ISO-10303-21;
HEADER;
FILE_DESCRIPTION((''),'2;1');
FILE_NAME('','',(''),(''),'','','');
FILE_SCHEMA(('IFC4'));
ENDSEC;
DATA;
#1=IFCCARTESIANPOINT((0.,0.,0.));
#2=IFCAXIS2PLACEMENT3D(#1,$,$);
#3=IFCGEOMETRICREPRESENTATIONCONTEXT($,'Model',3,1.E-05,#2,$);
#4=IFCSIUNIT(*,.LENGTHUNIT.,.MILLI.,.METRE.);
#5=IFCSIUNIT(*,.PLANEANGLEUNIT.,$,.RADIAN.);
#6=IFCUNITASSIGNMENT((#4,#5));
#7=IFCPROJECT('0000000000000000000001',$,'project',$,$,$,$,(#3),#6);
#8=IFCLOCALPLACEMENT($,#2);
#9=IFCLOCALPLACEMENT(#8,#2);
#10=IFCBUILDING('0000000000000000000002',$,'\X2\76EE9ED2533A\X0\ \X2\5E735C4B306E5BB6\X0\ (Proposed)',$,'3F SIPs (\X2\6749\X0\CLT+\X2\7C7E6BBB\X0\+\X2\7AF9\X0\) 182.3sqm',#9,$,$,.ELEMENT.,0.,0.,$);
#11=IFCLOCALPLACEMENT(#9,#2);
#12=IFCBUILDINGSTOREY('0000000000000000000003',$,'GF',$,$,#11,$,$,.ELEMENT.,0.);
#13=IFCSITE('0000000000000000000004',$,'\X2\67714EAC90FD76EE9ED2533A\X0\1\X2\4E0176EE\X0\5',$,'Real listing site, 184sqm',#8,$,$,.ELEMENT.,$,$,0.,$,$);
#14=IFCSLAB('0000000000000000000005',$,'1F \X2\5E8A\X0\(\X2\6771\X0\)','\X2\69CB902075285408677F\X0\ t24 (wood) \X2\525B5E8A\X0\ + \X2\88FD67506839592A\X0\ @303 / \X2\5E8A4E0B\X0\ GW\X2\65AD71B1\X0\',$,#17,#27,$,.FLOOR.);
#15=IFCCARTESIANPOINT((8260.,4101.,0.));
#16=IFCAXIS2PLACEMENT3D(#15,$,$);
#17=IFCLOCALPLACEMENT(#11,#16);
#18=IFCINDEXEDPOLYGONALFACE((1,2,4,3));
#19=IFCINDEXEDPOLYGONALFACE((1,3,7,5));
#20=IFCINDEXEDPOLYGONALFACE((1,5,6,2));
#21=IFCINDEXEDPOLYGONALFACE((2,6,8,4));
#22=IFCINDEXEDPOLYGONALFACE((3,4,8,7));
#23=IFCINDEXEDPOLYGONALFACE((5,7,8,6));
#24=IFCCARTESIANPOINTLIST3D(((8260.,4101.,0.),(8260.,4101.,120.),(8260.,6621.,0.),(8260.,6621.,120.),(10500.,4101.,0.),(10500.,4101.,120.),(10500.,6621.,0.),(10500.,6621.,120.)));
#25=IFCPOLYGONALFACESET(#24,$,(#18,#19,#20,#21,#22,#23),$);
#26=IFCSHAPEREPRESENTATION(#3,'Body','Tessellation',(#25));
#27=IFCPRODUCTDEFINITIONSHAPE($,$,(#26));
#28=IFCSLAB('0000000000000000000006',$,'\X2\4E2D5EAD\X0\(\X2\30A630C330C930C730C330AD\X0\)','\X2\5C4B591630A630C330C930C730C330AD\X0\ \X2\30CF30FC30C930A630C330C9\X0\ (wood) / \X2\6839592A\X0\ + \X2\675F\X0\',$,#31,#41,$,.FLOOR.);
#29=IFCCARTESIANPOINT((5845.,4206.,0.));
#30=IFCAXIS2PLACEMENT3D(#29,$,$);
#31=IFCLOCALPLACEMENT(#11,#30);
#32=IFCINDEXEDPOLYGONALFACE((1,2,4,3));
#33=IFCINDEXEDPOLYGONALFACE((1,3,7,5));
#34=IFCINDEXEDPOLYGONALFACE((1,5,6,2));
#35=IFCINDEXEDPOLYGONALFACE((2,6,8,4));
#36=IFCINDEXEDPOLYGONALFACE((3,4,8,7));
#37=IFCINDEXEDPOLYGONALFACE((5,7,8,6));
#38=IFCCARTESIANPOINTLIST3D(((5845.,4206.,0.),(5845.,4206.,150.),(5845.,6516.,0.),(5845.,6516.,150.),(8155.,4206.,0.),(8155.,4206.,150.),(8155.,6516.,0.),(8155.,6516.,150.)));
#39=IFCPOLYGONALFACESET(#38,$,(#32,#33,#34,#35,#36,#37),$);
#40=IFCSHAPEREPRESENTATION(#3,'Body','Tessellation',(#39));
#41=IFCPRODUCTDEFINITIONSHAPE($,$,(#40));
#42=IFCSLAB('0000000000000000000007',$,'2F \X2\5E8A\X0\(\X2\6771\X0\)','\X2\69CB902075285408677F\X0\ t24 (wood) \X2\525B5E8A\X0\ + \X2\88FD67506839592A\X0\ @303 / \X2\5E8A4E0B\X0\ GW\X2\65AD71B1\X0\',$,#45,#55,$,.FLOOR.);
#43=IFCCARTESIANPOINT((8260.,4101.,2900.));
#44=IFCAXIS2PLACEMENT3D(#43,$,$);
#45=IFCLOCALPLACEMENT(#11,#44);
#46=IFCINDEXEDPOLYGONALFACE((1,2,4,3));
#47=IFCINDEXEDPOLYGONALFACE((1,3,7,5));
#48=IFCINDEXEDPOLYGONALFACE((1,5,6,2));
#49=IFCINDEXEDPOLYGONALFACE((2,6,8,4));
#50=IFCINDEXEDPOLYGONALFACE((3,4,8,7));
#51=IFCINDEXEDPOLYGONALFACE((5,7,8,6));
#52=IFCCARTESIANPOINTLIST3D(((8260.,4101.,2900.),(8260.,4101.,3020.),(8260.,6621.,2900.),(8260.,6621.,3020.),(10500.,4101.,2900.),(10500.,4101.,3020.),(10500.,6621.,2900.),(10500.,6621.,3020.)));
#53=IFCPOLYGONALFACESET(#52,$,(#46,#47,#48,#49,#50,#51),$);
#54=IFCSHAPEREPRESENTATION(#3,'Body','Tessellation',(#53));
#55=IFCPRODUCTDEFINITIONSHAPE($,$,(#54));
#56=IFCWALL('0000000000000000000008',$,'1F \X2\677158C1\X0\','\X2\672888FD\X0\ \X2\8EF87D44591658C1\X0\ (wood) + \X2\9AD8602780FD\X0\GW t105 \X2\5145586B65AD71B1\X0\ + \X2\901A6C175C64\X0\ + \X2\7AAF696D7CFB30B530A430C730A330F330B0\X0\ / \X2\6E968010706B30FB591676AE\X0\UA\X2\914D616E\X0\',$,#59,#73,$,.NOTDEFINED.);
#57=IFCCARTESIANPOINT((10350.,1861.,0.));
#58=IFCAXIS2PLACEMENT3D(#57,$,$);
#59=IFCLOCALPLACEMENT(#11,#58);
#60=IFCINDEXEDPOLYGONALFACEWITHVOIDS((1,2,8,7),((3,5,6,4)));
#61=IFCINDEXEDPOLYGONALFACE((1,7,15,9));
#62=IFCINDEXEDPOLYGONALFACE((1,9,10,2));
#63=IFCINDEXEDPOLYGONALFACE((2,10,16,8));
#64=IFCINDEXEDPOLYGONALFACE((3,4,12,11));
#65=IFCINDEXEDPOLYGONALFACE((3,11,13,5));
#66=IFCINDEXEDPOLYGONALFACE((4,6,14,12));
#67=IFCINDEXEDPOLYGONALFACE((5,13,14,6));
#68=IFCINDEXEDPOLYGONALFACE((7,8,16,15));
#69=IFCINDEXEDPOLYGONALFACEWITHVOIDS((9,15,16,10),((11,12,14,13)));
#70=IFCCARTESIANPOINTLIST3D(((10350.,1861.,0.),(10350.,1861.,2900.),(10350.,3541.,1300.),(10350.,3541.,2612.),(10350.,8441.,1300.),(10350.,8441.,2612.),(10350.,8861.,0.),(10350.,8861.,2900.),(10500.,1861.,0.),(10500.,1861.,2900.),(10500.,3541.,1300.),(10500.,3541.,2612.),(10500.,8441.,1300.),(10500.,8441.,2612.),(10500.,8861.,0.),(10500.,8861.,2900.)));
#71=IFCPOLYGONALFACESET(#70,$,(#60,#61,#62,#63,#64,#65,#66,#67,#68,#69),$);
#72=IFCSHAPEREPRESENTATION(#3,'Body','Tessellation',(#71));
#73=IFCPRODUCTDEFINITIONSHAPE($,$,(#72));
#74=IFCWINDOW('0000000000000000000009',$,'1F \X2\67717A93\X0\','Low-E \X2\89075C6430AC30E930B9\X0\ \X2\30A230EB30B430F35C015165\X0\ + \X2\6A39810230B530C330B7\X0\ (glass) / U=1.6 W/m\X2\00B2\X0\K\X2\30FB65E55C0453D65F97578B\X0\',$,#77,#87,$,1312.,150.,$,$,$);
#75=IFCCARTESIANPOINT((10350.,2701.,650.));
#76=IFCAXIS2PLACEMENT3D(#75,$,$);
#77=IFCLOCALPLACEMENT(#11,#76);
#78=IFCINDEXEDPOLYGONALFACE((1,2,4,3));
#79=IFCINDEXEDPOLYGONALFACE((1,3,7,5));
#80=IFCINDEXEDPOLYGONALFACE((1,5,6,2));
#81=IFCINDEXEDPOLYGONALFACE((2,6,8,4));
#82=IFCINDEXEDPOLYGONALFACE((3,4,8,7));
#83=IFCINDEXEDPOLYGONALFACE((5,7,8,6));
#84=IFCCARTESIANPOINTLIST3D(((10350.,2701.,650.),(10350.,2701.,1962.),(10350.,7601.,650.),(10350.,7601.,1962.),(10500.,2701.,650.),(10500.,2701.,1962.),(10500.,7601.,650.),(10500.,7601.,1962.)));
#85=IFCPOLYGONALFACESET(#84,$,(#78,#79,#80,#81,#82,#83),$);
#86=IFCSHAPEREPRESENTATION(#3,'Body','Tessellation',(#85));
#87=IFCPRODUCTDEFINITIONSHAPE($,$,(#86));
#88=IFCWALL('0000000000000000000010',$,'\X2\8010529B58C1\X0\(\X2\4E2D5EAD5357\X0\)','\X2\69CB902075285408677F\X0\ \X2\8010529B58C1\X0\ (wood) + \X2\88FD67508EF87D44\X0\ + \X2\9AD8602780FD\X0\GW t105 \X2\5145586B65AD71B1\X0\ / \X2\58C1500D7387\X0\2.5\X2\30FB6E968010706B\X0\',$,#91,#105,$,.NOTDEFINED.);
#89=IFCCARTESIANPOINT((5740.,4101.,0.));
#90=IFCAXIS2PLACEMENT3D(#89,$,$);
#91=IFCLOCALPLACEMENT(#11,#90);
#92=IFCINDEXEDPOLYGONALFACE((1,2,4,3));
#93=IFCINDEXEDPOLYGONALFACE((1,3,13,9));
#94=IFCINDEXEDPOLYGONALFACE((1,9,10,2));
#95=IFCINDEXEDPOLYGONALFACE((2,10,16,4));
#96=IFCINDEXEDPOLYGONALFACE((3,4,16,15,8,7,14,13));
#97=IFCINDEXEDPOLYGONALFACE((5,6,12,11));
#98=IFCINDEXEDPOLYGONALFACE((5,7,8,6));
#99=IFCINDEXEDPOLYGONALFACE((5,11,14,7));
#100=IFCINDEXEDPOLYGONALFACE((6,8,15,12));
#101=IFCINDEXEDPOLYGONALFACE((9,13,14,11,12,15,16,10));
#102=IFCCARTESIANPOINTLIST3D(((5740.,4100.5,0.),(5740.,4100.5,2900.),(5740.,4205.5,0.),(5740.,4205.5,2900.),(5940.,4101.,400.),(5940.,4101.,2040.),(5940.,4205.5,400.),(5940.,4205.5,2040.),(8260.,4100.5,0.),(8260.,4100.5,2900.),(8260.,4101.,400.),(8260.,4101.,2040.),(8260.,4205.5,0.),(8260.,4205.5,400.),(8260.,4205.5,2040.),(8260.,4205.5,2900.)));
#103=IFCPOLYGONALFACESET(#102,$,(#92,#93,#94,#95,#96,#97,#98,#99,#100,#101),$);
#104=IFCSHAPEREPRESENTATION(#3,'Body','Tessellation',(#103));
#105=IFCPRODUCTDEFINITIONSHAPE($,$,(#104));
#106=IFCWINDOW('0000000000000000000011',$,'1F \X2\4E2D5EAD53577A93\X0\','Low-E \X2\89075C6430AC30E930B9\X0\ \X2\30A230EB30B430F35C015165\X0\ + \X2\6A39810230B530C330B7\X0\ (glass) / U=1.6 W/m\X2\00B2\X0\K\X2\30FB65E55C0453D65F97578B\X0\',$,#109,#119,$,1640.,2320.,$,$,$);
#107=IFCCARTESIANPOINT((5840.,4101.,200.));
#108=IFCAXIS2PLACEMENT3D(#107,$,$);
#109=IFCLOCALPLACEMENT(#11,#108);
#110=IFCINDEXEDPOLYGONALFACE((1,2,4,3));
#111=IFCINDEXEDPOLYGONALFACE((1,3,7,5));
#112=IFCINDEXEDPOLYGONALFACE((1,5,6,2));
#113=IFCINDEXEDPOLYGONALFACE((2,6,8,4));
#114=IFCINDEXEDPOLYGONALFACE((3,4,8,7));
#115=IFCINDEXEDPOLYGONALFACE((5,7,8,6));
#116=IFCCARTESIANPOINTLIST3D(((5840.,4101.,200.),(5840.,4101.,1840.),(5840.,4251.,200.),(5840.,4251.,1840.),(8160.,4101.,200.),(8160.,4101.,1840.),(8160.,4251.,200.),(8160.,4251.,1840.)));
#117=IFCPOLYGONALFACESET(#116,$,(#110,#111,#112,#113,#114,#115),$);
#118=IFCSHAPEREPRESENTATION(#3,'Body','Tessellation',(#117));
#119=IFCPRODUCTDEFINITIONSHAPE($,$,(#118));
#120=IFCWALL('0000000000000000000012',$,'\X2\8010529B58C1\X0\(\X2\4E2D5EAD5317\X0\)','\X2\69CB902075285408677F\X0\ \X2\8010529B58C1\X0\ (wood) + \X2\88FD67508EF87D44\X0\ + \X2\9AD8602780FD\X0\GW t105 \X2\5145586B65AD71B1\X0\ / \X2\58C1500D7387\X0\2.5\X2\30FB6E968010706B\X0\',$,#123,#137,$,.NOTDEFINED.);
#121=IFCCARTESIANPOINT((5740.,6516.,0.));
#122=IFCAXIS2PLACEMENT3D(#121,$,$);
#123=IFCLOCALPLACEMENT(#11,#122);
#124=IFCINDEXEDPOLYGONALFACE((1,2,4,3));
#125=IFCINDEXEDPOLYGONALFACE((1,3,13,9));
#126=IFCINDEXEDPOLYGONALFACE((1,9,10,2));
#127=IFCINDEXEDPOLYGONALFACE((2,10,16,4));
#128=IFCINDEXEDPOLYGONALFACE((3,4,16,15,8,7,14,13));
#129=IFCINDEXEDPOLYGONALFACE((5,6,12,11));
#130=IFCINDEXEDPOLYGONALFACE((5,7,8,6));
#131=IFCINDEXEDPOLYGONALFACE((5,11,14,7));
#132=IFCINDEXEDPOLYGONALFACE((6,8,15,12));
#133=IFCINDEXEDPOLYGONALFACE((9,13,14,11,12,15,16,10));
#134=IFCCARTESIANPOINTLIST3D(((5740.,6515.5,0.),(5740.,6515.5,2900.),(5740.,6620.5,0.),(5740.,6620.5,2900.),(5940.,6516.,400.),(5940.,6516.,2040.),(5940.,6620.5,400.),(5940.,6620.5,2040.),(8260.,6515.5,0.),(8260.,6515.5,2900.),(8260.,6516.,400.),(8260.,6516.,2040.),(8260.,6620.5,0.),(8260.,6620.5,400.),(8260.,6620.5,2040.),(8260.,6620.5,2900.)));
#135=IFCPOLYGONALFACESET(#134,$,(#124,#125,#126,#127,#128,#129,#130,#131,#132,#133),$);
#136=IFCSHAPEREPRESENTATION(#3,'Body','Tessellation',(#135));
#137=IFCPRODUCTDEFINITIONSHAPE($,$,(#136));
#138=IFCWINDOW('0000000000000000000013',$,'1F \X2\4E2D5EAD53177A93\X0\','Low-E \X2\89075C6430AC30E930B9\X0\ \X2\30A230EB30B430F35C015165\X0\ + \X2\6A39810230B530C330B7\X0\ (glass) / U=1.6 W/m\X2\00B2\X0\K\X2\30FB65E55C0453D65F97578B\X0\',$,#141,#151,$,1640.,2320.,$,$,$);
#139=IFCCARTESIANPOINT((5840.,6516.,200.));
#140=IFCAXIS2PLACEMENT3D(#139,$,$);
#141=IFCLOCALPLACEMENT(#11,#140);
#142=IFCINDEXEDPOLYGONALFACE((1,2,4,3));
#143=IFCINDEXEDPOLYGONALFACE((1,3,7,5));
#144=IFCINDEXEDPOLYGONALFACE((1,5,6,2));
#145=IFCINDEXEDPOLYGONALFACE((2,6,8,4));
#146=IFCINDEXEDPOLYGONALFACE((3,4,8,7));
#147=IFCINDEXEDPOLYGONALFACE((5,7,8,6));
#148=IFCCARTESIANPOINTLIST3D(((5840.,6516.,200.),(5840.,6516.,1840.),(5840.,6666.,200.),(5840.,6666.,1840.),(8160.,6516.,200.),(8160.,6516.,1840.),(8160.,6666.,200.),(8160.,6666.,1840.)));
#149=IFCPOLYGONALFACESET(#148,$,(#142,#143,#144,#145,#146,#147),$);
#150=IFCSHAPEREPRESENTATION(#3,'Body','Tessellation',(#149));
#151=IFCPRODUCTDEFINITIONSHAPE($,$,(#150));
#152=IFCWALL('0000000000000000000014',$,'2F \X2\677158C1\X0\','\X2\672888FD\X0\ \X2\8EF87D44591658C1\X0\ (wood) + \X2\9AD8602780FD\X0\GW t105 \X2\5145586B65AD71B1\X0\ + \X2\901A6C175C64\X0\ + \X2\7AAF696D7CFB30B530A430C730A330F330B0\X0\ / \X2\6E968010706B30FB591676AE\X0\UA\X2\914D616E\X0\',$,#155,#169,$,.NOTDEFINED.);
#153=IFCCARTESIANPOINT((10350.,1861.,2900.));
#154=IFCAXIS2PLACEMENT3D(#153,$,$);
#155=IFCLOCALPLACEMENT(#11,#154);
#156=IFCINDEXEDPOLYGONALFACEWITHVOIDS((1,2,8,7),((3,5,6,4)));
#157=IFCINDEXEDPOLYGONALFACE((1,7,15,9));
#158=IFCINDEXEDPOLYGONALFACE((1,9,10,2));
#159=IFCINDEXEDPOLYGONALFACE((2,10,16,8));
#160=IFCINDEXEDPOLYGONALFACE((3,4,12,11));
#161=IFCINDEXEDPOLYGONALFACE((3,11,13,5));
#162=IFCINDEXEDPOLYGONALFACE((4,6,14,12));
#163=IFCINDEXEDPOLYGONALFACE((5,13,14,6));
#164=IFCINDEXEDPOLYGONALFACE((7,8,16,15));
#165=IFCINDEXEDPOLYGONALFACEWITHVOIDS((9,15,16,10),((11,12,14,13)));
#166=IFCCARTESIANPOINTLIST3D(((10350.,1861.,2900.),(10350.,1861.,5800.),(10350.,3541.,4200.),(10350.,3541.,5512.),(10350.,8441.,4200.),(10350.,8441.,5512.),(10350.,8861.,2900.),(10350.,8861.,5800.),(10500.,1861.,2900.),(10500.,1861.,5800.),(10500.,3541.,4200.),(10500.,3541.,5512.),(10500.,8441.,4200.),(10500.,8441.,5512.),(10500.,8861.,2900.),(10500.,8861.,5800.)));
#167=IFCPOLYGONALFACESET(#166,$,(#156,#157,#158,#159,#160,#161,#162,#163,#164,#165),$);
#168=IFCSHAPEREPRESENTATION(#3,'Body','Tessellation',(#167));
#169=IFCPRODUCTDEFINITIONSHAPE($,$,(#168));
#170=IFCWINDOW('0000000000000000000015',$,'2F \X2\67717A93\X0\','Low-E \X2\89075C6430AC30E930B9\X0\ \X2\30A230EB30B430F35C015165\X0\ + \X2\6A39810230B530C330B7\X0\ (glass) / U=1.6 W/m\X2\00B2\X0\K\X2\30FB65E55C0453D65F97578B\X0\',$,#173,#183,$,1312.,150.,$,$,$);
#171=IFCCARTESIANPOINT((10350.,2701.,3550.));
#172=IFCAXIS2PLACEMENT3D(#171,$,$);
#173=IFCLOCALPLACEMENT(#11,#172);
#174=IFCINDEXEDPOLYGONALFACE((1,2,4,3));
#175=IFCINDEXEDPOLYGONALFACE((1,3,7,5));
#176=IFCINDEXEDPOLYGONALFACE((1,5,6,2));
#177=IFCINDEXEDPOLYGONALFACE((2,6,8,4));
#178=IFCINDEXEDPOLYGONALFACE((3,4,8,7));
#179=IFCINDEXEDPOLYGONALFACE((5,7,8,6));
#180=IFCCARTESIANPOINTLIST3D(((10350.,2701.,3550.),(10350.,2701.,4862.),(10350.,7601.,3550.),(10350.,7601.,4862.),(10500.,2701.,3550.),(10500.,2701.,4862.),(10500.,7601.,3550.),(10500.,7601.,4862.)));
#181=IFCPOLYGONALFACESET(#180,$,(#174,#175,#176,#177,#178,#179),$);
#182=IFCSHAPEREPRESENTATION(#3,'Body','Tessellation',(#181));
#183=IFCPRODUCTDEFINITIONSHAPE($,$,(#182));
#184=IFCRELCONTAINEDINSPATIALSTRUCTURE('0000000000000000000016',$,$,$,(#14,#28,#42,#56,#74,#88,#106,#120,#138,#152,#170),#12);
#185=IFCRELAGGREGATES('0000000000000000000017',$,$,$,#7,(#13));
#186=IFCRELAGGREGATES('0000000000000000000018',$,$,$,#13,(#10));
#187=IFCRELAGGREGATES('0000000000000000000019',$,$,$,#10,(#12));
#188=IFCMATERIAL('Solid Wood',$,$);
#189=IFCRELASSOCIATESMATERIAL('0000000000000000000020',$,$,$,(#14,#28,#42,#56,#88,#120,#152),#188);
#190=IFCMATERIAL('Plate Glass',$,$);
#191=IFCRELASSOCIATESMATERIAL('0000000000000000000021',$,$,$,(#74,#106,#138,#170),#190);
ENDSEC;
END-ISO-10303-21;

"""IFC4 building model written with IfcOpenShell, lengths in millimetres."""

from ifc_helpers import new_model, si_unit, frame, frame_2d, origin, place, context, project, spatial, rectangle, extrude, material, element, fill, save


model = new_model("IFC4")

# Units and contexts
model_context = context("Model", 3, precision=1e-05, world=origin())
ifc_project = project(units=[si_unit("LENGTHUNIT", "METRE", prefix="MILLI"), si_unit("PLANEANGLEUNIT", "RADIAN")], contexts=[model_context])

# Site, building, storey
site_placement = place(None, origin())
site = spatial("IfcSite", under=ifc_project, at=site_placement, Name="東京都目黒区1丁目5", ObjectType="Real listing site, 184sqm", CompositionType="ELEMENT", RefElevation=0.0)
building_placement = place(site_placement, origin())
building = spatial("IfcBuilding", under=site, at=building_placement, Name="目黒区 平屋の家 (Proposed)", ObjectType="3F SIPs (杉CLT+籾殻+竹) 182.3sqm", CompositionType="ELEMENT", ElevationOfRefHeight=0.0, ElevationOfTerrain=0.0)
storey_placement = place(building_placement, origin())
storey = spatial("IfcBuildingStorey", under=building, at=storey_placement, Name="GF", CompositionType="ELEMENT", Elevation=0.0)

# Slabs
ifc_material_1 = material(Name="Solid Wood")
slab_1_placement = place(storey_placement, frame((8260.0, 4101.0, 0.0)))
element("IfcSlab", 1, at=slab_1_placement, inside=storey, material=ifc_material_1, Name="1F 床(東)", Description="構造用合板 t24 (wood) 剛床 + 製材根太 @303 / 床下 GW断熱", PredefinedType="FLOOR", context=model_context, shape_type="SweptSolid", body=[
    extrude(rectangle(XDim=2240.0, YDim=2520.0, at=frame_2d((1120.0, 1260.0))), frame((8260.0, 4101.0, 0.0)), (0.0, 0.0, 1.0), 120.0),
])
slab_2_placement = place(storey_placement, frame((5845.0, 4206.0, 0.0)))
element("IfcSlab", 2, at=slab_2_placement, inside=storey, material=ifc_material_1, Name="中庭(ウッドデッキ)", Description="屋外ウッドデッキ ハードウッド (wood) / 根太 + 束", PredefinedType="FLOOR", context=model_context, shape_type="SweptSolid", body=[
    extrude(rectangle(XDim=2310.0, YDim=2310.0, at=frame_2d((1155.0, 1155.0))), frame((5845.0, 4206.0, 0.0)), (0.0, 0.0, 1.0), 150.0),
])
slab_3_placement = place(storey_placement, frame((8260.0, 4101.0, 2900.0)))
element("IfcSlab", 3, at=slab_3_placement, inside=storey, material=ifc_material_1, Name="2F 床(東)", Description="構造用合板 t24 (wood) 剛床 + 製材根太 @303 / 床下 GW断熱", PredefinedType="FLOOR", context=model_context, shape_type="SweptSolid", body=[
    extrude(rectangle(XDim=2240.0, YDim=2520.0, at=frame_2d((1120.0, 1260.0))), frame((8260.0, 4101.0, 2900.0)), (0.0, 0.0, 1.0), 120.0),
])

# Walls, openings, windows
wall_1_placement = place(storey_placement, frame((10350.0, 1861.0, 0.0)))
wall_1 = element("IfcWall", 4, at=wall_1_placement, inside=storey, material=ifc_material_1, Name="1F 東壁", Description="木製 軸組外壁 (wood) + 高性能GW t105 充填断熱 + 通気層 + 窯業系サイディング / 準耐火・外皮UA配慮", PredefinedType="NOTDEFINED", context=model_context, shape_type="SweptSolid", body=[
    extrude(rectangle(XDim=150.0, YDim=7000.0, at=frame_2d((75.0, 3500.0))), frame((10350.0, 1861.0, 0.0)), (0.0, 0.0, 1.0), 2900.0),
])
opening_1_placement = place(storey_placement, frame((10350.0, 2701.0, 650.0)))
opening_1 = element("IfcOpeningElement", 5, at=opening_1_placement, cuts=wall_1, PredefinedType="NOTDEFINED", context=model_context, shape_type="SweptSolid", body=[
    extrude(rectangle(XDim=150.0, YDim=4900.0, at=frame_2d((75.0, 2450.0))), frame((10350.0, 2701.0, 650.0)), (0.0, 0.0, 1.0), 1312.0),
])
ifc_material_2 = material(Name="Plate Glass")
window_1_placement = place(storey_placement, frame((10350.0, 2701.0, 650.0)))
window_1 = element("IfcWindow", 6, at=window_1_placement, inside=storey, material=ifc_material_2, Name="1F 東窓", Description="Low-E 複層ガラス アルゴン封入 + 樹脂サッシ (glass) / U=1.6 W/m²K・日射取得型", OverallHeight=1312.0, OverallWidth=150.0, context=model_context, shape_type="SweptSolid", body=[
    extrude(rectangle(XDim=150.0, YDim=4900.0, at=frame_2d((75.0, 2450.0))), frame((10350.0, 2701.0, 650.0)), (0.0, 0.0, 1.0), 1312.0),
])
fill(opening_1, window_1)
wall_2_placement = place(storey_placement, frame((5740.0, 4101.0, 0.0)))
wall_2 = element("IfcWall", 7, at=wall_2_placement, inside=storey, material=ifc_material_1, Name="耐力壁(中庭南)", Description="構造用合板 耐力壁 (wood) + 製材軸組 + 高性能GW t105 充填断熱 / 壁倍率2.5・準耐火", PredefinedType="NOTDEFINED", context=model_context, shape_type="SweptSolid", body=[
    extrude(rectangle(XDim=2520.0, YDim=105.0, at=frame_2d((1260.0, 52.0))), frame((5740.0, 4101.0, 0.0)), (0.0, 0.0, 1.0), 2900.0),
])
opening_2_placement = place(storey_placement, frame((5840.0, 4101.0, 200.0)))
opening_2 = element("IfcOpeningElement", 8, at=opening_2_placement, cuts=wall_2, PredefinedType="NOTDEFINED", context=model_context, shape_type="SweptSolid", body=[
    extrude(rectangle(XDim=2320.0, YDim=150.0, at=frame_2d((1160.0, 75.0))), frame((5840.0, 4101.0, 200.0)), (0.0, 0.0, 1.0), 1640.0),
])
window_2_placement = place(storey_placement, frame((5840.0, 4101.0, 200.0)))
window_2 = element("IfcWindow", 9, at=window_2_placement, inside=storey, material=ifc_material_2, Name="1F 中庭南窓", Description="Low-E 複層ガラス アルゴン封入 + 樹脂サッシ (glass) / U=1.6 W/m²K・日射取得型", OverallHeight=1640.0, OverallWidth=2320.0, context=model_context, shape_type="SweptSolid", body=[
    extrude(rectangle(XDim=2320.0, YDim=150.0, at=frame_2d((1160.0, 75.0))), frame((5840.0, 4101.0, 200.0)), (0.0, 0.0, 1.0), 1640.0),
])
fill(opening_2, window_2)
wall_3_placement = place(storey_placement, frame((5740.0, 6516.0, 0.0)))
wall_3 = element("IfcWall", 10, at=wall_3_placement, inside=storey, material=ifc_material_1, Name="耐力壁(中庭北)", Description="構造用合板 耐力壁 (wood) + 製材軸組 + 高性能GW t105 充填断熱 / 壁倍率2.5・準耐火", PredefinedType="NOTDEFINED", context=model_context, shape_type="SweptSolid", body=[
    extrude(rectangle(XDim=2520.0, YDim=105.0, at=frame_2d((1260.0, 52.0))), frame((5740.0, 6516.0, 0.0)), (0.0, 0.0, 1.0), 2900.0),
])
opening_3_placement = place(storey_placement, frame((5840.0, 6516.0, 200.0)))
opening_3 = element("IfcOpeningElement", 11, at=opening_3_placement, cuts=wall_3, PredefinedType="NOTDEFINED", context=model_context, shape_type="SweptSolid", body=[
    extrude(rectangle(XDim=2320.0, YDim=150.0, at=frame_2d((1160.0, 75.0))), frame((5840.0, 6516.0, 200.0)), (0.0, 0.0, 1.0), 1640.0),
])
window_3_placement = place(storey_placement, frame((5840.0, 6516.0, 200.0)))
window_3 = element("IfcWindow", 12, at=window_3_placement, inside=storey, material=ifc_material_2, Name="1F 中庭北窓", Description="Low-E 複層ガラス アルゴン封入 + 樹脂サッシ (glass) / U=1.6 W/m²K・日射取得型", OverallHeight=1640.0, OverallWidth=2320.0, context=model_context, shape_type="SweptSolid", body=[
    extrude(rectangle(XDim=2320.0, YDim=150.0, at=frame_2d((1160.0, 75.0))), frame((5840.0, 6516.0, 200.0)), (0.0, 0.0, 1.0), 1640.0),
])
fill(opening_3, window_3)

# Wall, opening, window
wall_4_placement = place(storey_placement, frame((10350.0, 1861.0, 2900.0)))
wall_4 = element("IfcWall", 13, at=wall_4_placement, inside=storey, material=ifc_material_1, Name="2F 東壁", Description="木製 軸組外壁 (wood) + 高性能GW t105 充填断熱 + 通気層 + 窯業系サイディング / 準耐火・外皮UA配慮", PredefinedType="NOTDEFINED", context=model_context, shape_type="SweptSolid", body=[
    extrude(rectangle(XDim=150.0, YDim=7000.0, at=frame_2d((75.0, 3500.0))), frame((10350.0, 1861.0, 2900.0)), (0.0, 0.0, 1.0), 2900.0),
])
opening_4_placement = place(storey_placement, frame((10350.0, 2701.0, 3550.0)))
opening_4 = element("IfcOpeningElement", 14, at=opening_4_placement, cuts=wall_4, PredefinedType="NOTDEFINED", context=model_context, shape_type="SweptSolid", body=[
    extrude(rectangle(XDim=150.0, YDim=4900.0, at=frame_2d((75.0, 2450.0))), frame((10350.0, 2701.0, 3550.0)), (0.0, 0.0, 1.0), 1312.0),
])
window_4_placement = place(storey_placement, frame((10350.0, 2701.0, 3550.0)))
window_4 = element("IfcWindow", 15, at=window_4_placement, inside=storey, material=ifc_material_2, Name="2F 東窓", Description="Low-E 複層ガラス アルゴン封入 + 樹脂サッシ (glass) / U=1.6 W/m²K・日射取得型", OverallHeight=1312.0, OverallWidth=150.0, context=model_context, shape_type="SweptSolid", body=[
    extrude(rectangle(XDim=150.0, YDim=4900.0, at=frame_2d((75.0, 2450.0))), frame((10350.0, 2701.0, 3550.0)), (0.0, 0.0, 1.0), 1312.0),
])
fill(opening_4, window_4)

save(model, "model.ifc")
